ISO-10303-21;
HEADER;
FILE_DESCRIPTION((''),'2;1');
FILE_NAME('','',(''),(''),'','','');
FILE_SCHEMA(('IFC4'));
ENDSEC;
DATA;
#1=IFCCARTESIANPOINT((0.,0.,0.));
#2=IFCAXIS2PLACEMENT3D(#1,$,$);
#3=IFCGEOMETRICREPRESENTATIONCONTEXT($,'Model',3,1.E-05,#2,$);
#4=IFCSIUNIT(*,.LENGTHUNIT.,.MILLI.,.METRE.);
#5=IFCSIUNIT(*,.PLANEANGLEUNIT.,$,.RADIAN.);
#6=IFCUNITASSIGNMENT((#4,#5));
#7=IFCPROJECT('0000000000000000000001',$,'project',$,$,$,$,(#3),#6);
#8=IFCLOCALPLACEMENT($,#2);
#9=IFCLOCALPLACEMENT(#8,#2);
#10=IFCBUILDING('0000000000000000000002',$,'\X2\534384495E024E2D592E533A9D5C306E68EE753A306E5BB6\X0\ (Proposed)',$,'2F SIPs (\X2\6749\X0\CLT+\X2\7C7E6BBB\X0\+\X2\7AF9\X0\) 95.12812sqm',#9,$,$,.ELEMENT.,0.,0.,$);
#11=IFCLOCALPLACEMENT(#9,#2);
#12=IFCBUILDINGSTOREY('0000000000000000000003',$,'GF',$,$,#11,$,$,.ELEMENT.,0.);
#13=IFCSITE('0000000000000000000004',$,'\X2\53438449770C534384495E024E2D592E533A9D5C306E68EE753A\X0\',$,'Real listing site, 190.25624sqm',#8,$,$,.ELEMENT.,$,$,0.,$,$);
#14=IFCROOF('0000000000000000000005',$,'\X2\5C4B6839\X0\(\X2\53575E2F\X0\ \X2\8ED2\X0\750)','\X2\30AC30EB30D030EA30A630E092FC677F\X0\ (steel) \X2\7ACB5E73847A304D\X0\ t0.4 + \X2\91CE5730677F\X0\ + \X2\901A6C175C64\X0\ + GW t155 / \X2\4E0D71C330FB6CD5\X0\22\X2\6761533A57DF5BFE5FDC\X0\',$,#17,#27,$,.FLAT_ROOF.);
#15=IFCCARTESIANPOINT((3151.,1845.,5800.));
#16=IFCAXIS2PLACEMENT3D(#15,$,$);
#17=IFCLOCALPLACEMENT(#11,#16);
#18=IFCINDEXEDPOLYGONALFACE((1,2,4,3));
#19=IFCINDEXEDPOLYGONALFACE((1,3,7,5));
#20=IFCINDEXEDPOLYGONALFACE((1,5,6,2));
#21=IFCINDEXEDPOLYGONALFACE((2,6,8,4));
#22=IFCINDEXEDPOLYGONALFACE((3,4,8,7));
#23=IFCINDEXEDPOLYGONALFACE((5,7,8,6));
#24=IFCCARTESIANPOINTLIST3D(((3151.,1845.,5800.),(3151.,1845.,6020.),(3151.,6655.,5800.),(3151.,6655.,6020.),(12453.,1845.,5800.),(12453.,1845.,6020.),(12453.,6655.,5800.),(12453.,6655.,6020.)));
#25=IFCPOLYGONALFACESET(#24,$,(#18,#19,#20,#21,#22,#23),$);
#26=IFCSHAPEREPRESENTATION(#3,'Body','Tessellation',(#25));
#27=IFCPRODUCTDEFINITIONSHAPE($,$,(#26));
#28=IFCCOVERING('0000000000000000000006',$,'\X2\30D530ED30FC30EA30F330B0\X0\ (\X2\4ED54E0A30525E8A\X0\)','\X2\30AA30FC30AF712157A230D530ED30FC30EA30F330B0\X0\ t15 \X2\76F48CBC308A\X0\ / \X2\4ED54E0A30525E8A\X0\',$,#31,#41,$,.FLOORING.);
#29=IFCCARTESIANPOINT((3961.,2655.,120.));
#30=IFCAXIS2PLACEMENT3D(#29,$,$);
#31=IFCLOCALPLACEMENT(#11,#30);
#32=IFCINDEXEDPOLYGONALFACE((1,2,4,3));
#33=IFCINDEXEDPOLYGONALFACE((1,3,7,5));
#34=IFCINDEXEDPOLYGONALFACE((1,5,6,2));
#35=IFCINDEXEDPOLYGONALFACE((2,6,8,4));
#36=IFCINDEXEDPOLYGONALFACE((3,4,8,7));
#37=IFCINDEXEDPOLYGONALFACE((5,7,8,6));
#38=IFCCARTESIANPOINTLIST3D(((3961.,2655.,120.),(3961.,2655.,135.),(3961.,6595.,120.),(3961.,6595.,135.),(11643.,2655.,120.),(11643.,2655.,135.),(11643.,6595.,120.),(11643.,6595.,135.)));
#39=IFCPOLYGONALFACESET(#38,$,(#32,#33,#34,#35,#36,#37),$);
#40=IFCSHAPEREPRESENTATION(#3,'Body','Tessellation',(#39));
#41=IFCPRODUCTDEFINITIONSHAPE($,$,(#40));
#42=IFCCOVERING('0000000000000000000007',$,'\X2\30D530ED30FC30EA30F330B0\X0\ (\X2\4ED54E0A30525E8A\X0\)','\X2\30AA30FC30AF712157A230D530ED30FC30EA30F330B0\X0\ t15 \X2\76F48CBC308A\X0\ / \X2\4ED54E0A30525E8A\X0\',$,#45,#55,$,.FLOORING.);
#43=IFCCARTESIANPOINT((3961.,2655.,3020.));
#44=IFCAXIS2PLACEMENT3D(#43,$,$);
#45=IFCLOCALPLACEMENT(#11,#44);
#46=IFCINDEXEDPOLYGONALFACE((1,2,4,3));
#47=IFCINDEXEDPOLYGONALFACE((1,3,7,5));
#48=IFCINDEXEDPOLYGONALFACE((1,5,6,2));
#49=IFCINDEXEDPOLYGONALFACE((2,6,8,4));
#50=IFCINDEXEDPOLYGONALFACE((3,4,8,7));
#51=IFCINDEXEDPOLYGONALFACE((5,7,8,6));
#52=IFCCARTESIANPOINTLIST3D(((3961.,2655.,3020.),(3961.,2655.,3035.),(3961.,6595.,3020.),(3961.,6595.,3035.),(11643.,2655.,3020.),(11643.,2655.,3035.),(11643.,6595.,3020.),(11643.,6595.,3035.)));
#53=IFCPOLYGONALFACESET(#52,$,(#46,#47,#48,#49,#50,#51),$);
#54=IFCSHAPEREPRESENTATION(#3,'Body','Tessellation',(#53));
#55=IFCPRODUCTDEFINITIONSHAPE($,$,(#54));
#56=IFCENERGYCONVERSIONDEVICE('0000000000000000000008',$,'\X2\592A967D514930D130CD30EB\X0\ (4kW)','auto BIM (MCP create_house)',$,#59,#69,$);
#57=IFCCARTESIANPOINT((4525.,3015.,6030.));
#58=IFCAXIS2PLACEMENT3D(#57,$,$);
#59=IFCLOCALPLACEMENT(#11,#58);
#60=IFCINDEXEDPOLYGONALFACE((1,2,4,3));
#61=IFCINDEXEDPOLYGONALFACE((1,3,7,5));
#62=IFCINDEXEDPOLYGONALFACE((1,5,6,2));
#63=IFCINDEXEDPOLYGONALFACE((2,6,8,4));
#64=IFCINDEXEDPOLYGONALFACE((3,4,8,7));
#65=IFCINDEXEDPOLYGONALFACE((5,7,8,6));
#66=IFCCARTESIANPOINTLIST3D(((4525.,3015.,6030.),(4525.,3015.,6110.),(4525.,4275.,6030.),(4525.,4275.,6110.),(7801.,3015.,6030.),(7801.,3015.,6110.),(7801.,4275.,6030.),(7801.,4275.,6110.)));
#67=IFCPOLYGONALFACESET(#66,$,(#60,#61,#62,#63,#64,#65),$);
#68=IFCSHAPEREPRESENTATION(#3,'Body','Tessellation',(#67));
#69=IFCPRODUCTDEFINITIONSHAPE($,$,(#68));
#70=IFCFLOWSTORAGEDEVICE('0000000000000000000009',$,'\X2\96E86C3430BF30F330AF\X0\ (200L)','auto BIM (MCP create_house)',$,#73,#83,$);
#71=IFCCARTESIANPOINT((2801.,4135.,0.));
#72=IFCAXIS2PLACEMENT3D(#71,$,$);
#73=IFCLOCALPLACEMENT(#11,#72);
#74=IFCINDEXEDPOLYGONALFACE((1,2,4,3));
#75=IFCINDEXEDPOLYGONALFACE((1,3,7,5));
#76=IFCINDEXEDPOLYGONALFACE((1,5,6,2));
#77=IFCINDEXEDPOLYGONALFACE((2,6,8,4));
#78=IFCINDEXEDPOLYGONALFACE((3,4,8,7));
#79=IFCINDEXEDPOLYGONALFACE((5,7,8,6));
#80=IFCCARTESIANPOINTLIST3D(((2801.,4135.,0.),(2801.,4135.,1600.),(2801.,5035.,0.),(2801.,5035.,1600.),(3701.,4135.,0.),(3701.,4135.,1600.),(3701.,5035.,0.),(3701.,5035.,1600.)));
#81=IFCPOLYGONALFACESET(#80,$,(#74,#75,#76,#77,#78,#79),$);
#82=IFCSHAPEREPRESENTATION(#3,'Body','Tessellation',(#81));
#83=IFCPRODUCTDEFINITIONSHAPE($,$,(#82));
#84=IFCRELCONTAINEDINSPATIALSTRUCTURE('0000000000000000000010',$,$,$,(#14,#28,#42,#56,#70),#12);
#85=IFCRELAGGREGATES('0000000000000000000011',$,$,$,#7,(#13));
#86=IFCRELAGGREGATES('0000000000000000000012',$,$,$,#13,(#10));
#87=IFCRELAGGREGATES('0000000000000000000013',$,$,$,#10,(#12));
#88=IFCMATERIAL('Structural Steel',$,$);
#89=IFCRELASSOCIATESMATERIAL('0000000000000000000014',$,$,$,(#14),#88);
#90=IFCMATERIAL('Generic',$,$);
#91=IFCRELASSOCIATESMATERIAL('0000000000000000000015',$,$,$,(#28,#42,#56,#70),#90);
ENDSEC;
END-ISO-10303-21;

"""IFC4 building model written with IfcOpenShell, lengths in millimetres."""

from ifc_helpers import new_model, si_unit, frame, frame_2d, origin, place, context, project, spatial, rectangle, extrude, material, element, save


model = new_model("IFC4")

# Units and contexts
model_context = context("Model", 3, precision=1e-05, world=origin())
ifc_project = project(units=[si_unit("LENGTHUNIT", "METRE", prefix="MILLI"), si_unit("PLANEANGLEUNIT", "RADIAN")], contexts=[model_context])

# Site, building, storey
site_placement = place(None, origin())
site = spatial("IfcSite", under=ifc_project, at=site_placement, Name="千葉県千葉市中央区鵜の森町", ObjectType="Real listing site, 190.25624sqm", CompositionType="ELEMENT", RefElevation=0.0)
building_placement = place(site_placement, origin())
building = spatial("IfcBuilding", under=site, at=building_placement, Name="千葉市中央区鵜の森町の家 (Proposed)", ObjectType="2F SIPs (杉CLT+籾殻+竹) 95.12812sqm", CompositionType="ELEMENT", ElevationOfRefHeight=0.0, ElevationOfTerrain=0.0)
storey_placement = place(building_placement, origin())
storey = spatial("IfcBuildingStorey", under=building, at=storey_placement, Name="GF", CompositionType="ELEMENT", Elevation=0.0)

# Roof
ifc_material_1 = material(Name="Structural Steel")
for number, where, name in (
    (1, (3151.0, 1845.0, 5800.0), "屋根(南帯 軒750)"),
):
    element("IfcRoof", number, at=place(storey_placement, frame(where)), inside=storey, material=ifc_material_1, Name=name, Description="ガルバリウム鋼板 (steel) 立平葺き t0.4 + 野地板 + 通気層 + GW t155 / 不燃・法22条区域対応", PredefinedType="FLAT_ROOF", context=model_context, shape_type="SweptSolid", body=[
        extrude(rectangle(XDim=9302.0, YDim=4810.0, at=frame_2d((4651.0, 2405.0))), frame((3151.0, 1845.0, 5800.0)), (0.0, 0.0, 1.0), 220.0),
    ])

# Coverings
ifc_material_2 = material(Name="Generic")
covering_1_placement = place(storey_placement, frame((3961.0, 2655.0, 120.0)))
element("IfcCovering", 2, at=covering_1_placement, inside=storey, material=ifc_material_2, Name="フローリング (仕上げ床)", Description="オーク無垢フローリング t15 直貼り / 仕上げ床", PredefinedType="FLOORING", context=model_context, shape_type="SweptSolid", body=[
    extrude(rectangle(XDim=7682.0, YDim=3940.0, at=frame_2d((3841.0, 1970.0))), frame((3961.0, 2655.0, 120.0)), (0.0, 0.0, 1.0), 15.0),
])
covering_2_placement = place(storey_placement, frame((3961.0, 2655.0, 3020.0)))
element("IfcCovering", 3, at=covering_2_placement, inside=storey, material=ifc_material_2, Name="フローリング (仕上げ床)", Description="オーク無垢フローリング t15 直貼り / 仕上げ床", PredefinedType="FLOORING", context=model_context, shape_type="SweptSolid", body=[
    extrude(rectangle(XDim=7682.0, YDim=3940.0, at=frame_2d((3841.0, 1970.0))), frame((3961.0, 2655.0, 3020.0)), (0.0, 0.0, 1.0), 15.0),
])

# Energy conversion device
energy_conversion_device_placement = place(storey_placement, frame((4525.0, 3015.0, 6030.0)))
element("IfcEnergyConversionDevice", 4, at=energy_conversion_device_placement, inside=storey, material=ifc_material_2, Name="太陽光パネル (4kW)", Description="auto BIM (MCP create_house)", context=model_context, shape_type="SweptSolid", body=[
    extrude(rectangle(XDim=3276.0, YDim=1260.0, at=frame_2d((1638.0, 630.0))), frame((4525.0, 3015.0, 6030.0)), (0.0, 0.0, 1.0), 80.0),
])

# Flow storage device
flow_storage_device_placement = place(storey_placement, frame((2801.0, 4135.0, 0.0)))
element("IfcFlowStorageDevice", 5, at=flow_storage_device_placement, inside=storey, material=ifc_material_2, Name="雨水タンク (200L)", Description="auto BIM (MCP create_house)", context=model_context, shape_type="SweptSolid", body=[
    extrude(rectangle(XDim=900.0, YDim=900.0, at=frame_2d((450.0, 450.0))), frame((2801.0, 4135.0, 0.0)), (0.0, 0.0, 1.0), 1600.0),
])

save(model, "model.ifc")
